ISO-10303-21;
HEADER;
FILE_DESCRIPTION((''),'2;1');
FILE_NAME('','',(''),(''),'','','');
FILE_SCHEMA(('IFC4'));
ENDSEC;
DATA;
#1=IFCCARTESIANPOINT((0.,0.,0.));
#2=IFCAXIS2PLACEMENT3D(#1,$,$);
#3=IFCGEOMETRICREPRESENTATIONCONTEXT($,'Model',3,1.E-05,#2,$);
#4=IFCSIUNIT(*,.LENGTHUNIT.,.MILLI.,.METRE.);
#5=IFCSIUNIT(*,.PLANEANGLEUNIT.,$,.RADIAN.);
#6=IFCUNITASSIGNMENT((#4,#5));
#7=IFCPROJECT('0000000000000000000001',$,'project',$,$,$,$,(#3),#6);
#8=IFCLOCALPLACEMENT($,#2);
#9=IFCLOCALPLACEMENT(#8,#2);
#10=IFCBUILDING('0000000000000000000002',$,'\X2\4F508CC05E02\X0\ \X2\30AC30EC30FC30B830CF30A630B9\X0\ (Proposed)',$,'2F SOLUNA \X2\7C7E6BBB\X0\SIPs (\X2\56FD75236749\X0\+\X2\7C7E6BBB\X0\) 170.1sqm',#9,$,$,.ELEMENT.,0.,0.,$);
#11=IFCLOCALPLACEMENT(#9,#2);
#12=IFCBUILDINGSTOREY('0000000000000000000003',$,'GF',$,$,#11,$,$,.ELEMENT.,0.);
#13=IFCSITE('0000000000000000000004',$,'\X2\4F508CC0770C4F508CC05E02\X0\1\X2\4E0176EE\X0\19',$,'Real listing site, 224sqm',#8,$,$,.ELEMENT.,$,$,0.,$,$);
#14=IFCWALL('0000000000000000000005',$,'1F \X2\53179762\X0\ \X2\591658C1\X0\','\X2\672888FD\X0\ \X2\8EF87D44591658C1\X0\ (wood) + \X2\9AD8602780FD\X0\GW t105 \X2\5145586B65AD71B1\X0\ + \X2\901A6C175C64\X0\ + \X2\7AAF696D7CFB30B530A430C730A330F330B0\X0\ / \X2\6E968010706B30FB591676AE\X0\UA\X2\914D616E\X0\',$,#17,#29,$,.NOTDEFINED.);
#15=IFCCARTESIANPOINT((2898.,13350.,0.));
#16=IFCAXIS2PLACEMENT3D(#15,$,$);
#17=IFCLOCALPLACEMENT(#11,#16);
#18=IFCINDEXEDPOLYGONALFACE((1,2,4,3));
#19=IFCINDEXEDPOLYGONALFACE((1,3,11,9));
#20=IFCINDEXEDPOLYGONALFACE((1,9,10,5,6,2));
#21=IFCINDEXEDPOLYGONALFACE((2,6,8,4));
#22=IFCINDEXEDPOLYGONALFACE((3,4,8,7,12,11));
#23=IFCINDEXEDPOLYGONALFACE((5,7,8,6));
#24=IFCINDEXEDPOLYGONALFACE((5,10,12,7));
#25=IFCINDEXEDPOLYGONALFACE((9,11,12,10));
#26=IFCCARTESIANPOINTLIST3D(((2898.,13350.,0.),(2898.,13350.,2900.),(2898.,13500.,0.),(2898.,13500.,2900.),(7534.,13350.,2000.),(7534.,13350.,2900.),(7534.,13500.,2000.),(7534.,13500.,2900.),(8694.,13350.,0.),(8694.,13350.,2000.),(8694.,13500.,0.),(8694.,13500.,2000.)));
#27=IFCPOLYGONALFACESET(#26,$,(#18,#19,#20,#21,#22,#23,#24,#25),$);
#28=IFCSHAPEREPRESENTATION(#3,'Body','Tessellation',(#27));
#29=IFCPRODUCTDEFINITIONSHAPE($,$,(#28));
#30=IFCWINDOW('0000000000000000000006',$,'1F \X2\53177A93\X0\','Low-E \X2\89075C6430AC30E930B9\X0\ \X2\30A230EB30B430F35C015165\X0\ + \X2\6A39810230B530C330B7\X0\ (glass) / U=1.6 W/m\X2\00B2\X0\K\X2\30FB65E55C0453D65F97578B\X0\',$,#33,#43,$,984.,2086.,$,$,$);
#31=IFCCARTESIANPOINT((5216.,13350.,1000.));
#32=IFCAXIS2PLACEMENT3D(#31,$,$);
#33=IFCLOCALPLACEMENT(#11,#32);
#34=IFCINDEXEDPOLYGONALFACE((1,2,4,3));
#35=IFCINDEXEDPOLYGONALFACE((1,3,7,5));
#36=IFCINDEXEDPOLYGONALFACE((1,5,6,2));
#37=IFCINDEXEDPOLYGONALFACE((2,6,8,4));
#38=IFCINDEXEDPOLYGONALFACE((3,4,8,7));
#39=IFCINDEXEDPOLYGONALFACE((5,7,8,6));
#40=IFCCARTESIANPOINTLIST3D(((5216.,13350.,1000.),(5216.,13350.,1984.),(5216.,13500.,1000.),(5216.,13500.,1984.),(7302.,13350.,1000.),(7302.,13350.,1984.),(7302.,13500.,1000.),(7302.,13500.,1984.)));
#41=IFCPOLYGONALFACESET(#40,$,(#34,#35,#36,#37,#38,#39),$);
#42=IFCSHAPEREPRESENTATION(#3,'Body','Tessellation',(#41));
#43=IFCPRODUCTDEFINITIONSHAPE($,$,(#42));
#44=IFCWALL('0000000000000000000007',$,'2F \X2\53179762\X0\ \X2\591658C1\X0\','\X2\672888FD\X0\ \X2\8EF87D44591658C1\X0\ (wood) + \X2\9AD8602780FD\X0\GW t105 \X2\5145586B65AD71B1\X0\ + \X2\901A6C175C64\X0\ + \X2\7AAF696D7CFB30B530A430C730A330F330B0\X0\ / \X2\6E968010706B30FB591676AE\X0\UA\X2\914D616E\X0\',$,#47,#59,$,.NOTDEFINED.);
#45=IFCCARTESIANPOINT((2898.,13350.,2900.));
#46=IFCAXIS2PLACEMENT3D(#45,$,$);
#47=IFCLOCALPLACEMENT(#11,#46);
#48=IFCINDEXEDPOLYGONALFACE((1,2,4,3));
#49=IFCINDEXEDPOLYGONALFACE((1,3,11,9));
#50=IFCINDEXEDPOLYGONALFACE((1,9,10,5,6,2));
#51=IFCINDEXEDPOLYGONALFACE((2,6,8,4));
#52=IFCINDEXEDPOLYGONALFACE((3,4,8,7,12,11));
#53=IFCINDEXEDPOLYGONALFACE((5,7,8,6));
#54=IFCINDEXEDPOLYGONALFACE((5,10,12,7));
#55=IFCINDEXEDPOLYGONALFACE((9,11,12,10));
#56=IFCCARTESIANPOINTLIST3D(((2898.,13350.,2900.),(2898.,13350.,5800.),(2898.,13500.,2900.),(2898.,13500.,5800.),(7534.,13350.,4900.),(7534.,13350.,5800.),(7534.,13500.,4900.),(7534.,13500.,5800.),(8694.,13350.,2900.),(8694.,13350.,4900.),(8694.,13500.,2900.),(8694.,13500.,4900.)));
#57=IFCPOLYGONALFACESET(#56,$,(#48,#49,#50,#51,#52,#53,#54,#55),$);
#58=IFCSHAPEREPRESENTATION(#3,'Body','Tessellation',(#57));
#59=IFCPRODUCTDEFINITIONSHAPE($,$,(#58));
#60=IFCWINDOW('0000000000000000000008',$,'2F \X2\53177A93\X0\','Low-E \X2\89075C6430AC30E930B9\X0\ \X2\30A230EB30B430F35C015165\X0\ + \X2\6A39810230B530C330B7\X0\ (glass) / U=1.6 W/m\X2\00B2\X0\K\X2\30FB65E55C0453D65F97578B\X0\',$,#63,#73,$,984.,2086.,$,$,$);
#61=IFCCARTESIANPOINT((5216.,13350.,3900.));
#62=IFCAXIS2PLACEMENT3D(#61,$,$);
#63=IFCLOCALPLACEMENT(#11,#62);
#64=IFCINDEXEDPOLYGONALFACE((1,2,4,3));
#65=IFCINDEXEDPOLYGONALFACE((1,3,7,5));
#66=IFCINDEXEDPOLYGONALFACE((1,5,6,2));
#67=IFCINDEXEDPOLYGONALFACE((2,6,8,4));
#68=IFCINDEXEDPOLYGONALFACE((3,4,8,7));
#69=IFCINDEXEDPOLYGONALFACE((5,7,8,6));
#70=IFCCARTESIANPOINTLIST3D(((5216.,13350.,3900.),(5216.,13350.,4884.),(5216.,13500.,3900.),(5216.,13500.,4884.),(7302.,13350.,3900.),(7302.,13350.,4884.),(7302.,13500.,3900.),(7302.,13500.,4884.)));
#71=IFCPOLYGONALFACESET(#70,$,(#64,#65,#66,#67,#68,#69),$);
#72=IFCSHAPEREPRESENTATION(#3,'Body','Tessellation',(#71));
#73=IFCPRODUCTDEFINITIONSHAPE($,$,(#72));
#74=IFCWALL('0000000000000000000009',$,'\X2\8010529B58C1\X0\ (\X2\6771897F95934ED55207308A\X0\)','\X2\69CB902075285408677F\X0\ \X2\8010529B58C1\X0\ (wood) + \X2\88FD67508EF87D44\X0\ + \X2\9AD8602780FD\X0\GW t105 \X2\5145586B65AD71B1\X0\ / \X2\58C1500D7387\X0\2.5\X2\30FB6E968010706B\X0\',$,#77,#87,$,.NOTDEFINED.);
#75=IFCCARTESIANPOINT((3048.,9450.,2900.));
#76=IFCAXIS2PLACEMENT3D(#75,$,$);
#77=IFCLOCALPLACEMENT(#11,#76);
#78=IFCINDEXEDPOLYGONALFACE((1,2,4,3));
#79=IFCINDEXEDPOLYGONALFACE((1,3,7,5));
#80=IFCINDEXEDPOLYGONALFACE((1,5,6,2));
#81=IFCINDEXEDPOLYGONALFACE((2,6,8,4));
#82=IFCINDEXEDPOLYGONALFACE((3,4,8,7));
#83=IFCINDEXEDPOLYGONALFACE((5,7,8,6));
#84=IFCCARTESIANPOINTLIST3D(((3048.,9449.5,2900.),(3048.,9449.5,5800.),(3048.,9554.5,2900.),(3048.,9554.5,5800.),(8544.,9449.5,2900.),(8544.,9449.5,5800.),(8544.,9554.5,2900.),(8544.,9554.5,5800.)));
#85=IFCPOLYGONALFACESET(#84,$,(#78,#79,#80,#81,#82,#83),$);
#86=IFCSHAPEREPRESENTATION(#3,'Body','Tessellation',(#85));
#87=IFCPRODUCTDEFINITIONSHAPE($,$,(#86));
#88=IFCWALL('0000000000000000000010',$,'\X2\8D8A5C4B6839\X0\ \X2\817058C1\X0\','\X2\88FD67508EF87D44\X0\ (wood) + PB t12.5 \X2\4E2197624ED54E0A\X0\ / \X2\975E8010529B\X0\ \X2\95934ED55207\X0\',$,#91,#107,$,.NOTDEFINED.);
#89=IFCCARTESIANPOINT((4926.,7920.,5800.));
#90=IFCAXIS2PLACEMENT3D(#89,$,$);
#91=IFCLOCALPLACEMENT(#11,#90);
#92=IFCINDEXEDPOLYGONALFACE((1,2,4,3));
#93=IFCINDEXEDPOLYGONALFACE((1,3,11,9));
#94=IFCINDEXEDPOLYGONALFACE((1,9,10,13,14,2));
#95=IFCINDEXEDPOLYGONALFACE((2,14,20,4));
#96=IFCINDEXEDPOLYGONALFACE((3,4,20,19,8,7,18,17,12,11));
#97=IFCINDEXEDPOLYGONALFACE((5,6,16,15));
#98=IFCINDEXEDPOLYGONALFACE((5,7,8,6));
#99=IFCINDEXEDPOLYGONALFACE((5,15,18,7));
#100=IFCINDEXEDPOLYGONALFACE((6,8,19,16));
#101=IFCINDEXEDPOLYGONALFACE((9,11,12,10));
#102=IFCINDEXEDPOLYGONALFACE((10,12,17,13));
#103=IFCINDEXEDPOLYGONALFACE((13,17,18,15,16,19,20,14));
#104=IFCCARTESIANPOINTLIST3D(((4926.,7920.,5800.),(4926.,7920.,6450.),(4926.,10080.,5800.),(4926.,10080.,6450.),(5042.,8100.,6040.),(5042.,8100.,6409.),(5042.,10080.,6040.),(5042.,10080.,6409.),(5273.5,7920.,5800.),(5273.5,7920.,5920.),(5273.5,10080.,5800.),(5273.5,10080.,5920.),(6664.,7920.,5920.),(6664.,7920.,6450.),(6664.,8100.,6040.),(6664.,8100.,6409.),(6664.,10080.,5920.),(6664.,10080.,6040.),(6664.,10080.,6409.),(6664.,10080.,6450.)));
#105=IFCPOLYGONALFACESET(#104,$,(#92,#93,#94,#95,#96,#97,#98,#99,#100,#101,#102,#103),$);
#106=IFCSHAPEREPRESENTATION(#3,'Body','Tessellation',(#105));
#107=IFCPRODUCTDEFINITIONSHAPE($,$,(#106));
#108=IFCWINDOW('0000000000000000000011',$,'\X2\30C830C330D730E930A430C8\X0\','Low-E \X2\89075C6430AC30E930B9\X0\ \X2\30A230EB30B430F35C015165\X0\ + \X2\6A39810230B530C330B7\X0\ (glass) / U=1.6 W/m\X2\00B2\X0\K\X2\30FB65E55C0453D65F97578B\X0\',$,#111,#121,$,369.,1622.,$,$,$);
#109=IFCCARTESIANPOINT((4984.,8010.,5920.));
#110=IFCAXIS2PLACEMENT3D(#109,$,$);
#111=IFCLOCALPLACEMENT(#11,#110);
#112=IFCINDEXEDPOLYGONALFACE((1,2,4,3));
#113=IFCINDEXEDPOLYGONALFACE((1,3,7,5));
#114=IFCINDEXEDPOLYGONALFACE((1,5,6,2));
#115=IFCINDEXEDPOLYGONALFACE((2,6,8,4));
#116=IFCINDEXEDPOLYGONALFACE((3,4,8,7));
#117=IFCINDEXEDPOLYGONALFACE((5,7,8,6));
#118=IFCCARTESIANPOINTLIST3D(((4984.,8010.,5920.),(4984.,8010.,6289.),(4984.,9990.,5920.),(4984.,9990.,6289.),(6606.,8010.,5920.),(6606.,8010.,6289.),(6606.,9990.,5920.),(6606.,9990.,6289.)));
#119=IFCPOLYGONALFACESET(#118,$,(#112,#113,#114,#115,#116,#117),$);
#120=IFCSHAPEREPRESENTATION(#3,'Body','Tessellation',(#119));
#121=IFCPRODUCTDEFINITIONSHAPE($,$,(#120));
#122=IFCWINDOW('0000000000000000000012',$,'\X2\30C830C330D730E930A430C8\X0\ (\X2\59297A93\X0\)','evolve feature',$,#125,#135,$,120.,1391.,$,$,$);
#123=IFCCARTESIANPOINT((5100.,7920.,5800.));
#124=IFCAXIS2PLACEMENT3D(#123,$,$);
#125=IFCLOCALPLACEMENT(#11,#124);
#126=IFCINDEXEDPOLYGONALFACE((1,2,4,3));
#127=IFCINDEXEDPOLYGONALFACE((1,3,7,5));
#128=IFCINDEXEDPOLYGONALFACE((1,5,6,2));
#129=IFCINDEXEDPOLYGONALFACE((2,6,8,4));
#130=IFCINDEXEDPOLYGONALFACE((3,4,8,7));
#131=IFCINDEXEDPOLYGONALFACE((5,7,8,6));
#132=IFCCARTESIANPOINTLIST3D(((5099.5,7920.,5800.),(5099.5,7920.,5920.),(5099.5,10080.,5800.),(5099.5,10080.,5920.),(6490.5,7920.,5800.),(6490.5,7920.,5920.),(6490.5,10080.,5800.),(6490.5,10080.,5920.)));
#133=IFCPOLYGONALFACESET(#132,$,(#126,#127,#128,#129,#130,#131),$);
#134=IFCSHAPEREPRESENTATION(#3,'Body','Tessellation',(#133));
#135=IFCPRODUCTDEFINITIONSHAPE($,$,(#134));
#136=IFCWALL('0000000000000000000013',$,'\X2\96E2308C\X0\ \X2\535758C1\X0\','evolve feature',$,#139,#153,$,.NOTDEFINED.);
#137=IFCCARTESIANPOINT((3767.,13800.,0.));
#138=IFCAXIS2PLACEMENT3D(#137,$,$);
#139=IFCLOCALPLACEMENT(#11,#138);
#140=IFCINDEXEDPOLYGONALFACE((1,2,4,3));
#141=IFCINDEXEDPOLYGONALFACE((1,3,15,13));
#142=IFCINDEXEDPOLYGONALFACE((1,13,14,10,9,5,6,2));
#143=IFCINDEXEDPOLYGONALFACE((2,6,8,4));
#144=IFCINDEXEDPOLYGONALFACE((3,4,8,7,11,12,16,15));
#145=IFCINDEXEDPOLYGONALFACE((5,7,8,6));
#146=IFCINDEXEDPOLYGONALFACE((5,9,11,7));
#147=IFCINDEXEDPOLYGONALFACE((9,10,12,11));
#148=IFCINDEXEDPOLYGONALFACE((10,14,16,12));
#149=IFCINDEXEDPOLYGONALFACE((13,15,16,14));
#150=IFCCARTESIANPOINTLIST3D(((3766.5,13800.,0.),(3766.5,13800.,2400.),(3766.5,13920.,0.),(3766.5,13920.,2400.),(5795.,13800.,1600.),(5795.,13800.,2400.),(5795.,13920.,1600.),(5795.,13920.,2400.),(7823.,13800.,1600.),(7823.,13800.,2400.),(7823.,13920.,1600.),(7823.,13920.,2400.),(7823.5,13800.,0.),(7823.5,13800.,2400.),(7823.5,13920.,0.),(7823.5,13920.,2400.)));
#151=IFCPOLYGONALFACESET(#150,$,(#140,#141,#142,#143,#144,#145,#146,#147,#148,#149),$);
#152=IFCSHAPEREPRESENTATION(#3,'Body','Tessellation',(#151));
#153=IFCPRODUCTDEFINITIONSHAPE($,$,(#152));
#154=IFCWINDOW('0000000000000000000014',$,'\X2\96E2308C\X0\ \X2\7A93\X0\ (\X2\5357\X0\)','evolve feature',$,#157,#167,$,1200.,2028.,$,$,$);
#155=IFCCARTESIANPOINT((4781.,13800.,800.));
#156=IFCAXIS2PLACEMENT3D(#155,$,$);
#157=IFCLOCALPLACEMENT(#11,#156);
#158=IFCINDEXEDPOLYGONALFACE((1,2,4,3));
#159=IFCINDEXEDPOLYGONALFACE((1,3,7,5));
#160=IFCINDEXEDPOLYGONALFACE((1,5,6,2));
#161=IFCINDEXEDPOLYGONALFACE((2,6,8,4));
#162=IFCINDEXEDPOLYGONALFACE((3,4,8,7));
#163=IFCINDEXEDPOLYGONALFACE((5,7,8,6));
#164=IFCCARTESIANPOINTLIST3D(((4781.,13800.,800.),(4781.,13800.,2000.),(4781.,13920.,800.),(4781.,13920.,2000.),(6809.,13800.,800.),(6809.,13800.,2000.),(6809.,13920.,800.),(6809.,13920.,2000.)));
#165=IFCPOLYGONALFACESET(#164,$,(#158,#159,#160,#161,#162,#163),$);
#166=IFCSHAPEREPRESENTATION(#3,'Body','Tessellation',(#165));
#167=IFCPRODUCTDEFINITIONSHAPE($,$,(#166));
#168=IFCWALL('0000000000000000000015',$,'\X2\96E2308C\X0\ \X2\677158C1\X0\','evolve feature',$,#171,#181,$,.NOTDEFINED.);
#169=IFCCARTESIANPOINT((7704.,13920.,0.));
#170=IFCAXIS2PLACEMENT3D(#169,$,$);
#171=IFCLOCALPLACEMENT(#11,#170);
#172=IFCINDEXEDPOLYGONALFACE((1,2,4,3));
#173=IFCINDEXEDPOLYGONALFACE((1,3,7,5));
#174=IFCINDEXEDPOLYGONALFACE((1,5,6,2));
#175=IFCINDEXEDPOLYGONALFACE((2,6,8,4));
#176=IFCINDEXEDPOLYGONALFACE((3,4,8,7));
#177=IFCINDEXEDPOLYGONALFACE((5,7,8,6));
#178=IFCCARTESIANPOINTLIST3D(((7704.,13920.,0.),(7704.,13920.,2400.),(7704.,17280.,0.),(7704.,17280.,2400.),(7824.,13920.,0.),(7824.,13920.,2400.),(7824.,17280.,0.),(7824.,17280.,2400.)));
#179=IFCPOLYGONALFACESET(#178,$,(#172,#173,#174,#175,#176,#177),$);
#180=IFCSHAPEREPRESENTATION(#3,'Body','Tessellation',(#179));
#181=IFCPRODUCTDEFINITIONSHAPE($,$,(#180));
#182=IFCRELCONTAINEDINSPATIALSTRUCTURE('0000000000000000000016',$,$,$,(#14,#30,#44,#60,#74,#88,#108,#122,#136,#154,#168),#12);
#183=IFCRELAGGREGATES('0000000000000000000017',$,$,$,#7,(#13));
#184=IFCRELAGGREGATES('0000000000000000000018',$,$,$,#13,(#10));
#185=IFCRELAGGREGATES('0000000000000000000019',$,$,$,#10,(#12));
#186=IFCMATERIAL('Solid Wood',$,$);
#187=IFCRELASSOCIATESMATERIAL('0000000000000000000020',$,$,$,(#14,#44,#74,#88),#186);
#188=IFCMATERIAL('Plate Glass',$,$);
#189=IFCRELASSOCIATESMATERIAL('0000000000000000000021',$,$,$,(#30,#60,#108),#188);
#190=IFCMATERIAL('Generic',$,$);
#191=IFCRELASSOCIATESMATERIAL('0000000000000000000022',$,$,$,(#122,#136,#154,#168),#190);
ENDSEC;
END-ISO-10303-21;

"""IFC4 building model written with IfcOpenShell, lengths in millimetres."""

from ifc_helpers import new_model, si_unit, frame, frame_2d, origin, place, context, project, spatial, rectangle, extrude, material, element, fill, save


model = new_model("IFC4")

# Units and contexts
model_context = context("Model", 3, precision=1e-05, world=origin())
ifc_project = project(units=[si_unit("LENGTHUNIT", "METRE", prefix="MILLI"), si_unit("PLANEANGLEUNIT", "RADIAN")], contexts=[model_context])

# Site, building, storey
site_placement = place(None, origin())
site = spatial("IfcSite", under=ifc_project, at=site_placement, Name="佐賀県佐賀市1丁目19", ObjectType="Real listing site, 224sqm", CompositionType="ELEMENT", RefElevation=0.0)
building_placement = place(site_placement, origin())
building = spatial("IfcBuilding", under=site, at=building_placement, Name="佐賀市 ガレージハウス (Proposed)", ObjectType="2F SOLUNA 籾殻SIPs (国産杉+籾殻) 170.1sqm", CompositionType="ELEMENT", ElevationOfRefHeight=0.0, ElevationOfTerrain=0.0)
storey_placement = place(building_placement, origin())
storey = spatial("IfcBuildingStorey", under=building, at=storey_placement, Name="GF", CompositionType="ELEMENT", Elevation=0.0)

# Shared definitions
ifc_material_1 = material(Name="Generic")

# Wall, opening, window
ifc_material_2 = material(Name="Solid Wood")
wall_1_placement = place(storey_placement, frame((2898.0, 13350.0, 0.0)))
wall_1 = element("IfcWall", 1, at=wall_1_placement, inside=storey, material=ifc_material_2, Name="1F 北面 外壁", Description="木製 軸組外壁 (wood) + 高性能GW t105 充填断熱 + 通気層 + 窯業系サイディング / 準耐火・外皮UA配慮", PredefinedType="NOTDEFINED", context=model_context, shape_type="SweptSolid", body=[
    extrude(rectangle(XDim=5796.0, YDim=150.0, at=frame_2d((2898.0, 75.0))), frame((2898.0, 13350.0, 0.0)), (0.0, 0.0, 1.0), 2900.0),
])
opening_1_placement = place(storey_placement, frame((5216.0, 13350.0, 1000.0)))
opening_1 = element("IfcOpeningElement", 2, at=opening_1_placement, cuts=wall_1, PredefinedType="NOTDEFINED", context=model_context, shape_type="SweptSolid", body=[
    extrude(rectangle(XDim=2086.0, YDim=150.0, at=frame_2d((1043.0, 75.0))), frame((5216.0, 13350.0, 1000.0)), (0.0, 0.0, 1.0), 984.0),
])
ifc_material_3 = material(Name="Plate Glass")
window_1_placement = place(storey_placement, frame((5216.0, 13350.0, 1000.0)))
window_1 = element("IfcWindow", 3, at=window_1_placement, inside=storey, material=ifc_material_3, Name="1F 北窓", Description="Low-E 複層ガラス アルゴン封入 + 樹脂サッシ (glass) / U=1.6 W/m²K・日射取得型", OverallHeight=984.0, OverallWidth=2086.0, context=model_context, shape_type="SweptSolid", body=[
    extrude(rectangle(XDim=2086.0, YDim=150.0, at=frame_2d((1043.0, 75.0))), frame((5216.0, 13350.0, 1000.0)), (0.0, 0.0, 1.0), 984.0),
])
fill(opening_1, window_1)

# Wall, opening, window
wall_2_placement = place(storey_placement, frame((2898.0, 13350.0, 2900.0)))
wall_2 = element("IfcWall", 4, at=wall_2_placement, inside=storey, material=ifc_material_2, Name="2F 北面 外壁", Description="木製 軸組外壁 (wood) + 高性能GW t105 充填断熱 + 通気層 + 窯業系サイディング / 準耐火・外皮UA配慮", PredefinedType="NOTDEFINED", context=model_context, shape_type="SweptSolid", body=[
    extrude(rectangle(XDim=5796.0, YDim=150.0, at=frame_2d((2898.0, 75.0))), frame((2898.0, 13350.0, 2900.0)), (0.0, 0.0, 1.0), 2900.0),
])
opening_2_placement = place(storey_placement, frame((5216.0, 13350.0, 3900.0)))
opening_2 = element("IfcOpeningElement", 5, at=opening_2_placement, cuts=wall_2, PredefinedType="NOTDEFINED", context=model_context, shape_type="SweptSolid", body=[
    extrude(rectangle(XDim=2086.0, YDim=150.0, at=frame_2d((1043.0, 75.0))), frame((5216.0, 13350.0, 3900.0)), (0.0, 0.0, 1.0), 984.0),
])
window_2_placement = place(storey_placement, frame((5216.0, 13350.0, 3900.0)))
window_2 = element("IfcWindow", 6, at=window_2_placement, inside=storey, material=ifc_material_3, Name="2F 北窓", Description="Low-E 複層ガラス アルゴン封入 + 樹脂サッシ (glass) / U=1.6 W/m²K・日射取得型", OverallHeight=984.0, OverallWidth=2086.0, context=model_context, shape_type="SweptSolid", body=[
    extrude(rectangle(XDim=2086.0, YDim=150.0, at=frame_2d((1043.0, 75.0))), frame((5216.0, 13350.0, 3900.0)), (0.0, 0.0, 1.0), 984.0),
])
fill(opening_2, window_2)

# Wall
wall_3_placement = place(storey_placement, frame((3048.0, 9450.0, 2900.0)))
element("IfcWall", 7, at=wall_3_placement, inside=storey, material=ifc_material_2, Name="耐力壁 (東西間仕切り)", Description="構造用合板 耐力壁 (wood) + 製材軸組 + 高性能GW t105 充填断熱 / 壁倍率2.5・準耐火", PredefinedType="NOTDEFINED", context=model_context, shape_type="SweptSolid", body=[
    extrude(rectangle(XDim=5496.0, YDim=105.0, at=frame_2d((2748.0, 52.0))), frame((3048.0, 9450.0, 2900.0)), (0.0, 0.0, 1.0), 2900.0),
])

# Wall, openings, windows
wall_4_placement = place(storey_placement, frame((4926.0, 7920.0, 5800.0)))
wall_4 = element("IfcWall", 8, at=wall_4_placement, inside=storey, material=ifc_material_2, Name="越屋根 腰壁", Description="製材軸組 (wood) + PB t12.5 両面仕上 / 非耐力 間仕切", PredefinedType="NOTDEFINED", context=model_context, shape_type="SweptSolid", body=[
    extrude(rectangle(XDim=1738.0, YDim=2160.0, at=frame_2d((869.0, 1080.0))), frame((4926.0, 7920.0, 5800.0)), (0.0, 0.0, 1.0), 650.0),
])
opening_3_placement = place(storey_placement, frame((4984.0, 8010.0, 5920.0)))
opening_3 = element("IfcOpeningElement", 9, at=opening_3_placement, cuts=wall_4, PredefinedType="NOTDEFINED", context=model_context, shape_type="SweptSolid", body=[
    extrude(rectangle(XDim=1622.0, YDim=1980.0, at=frame_2d((811.0, 990.0))), frame((4984.0, 8010.0, 5920.0)), (0.0, 0.0, 1.0), 369.0),
])
opening_4_placement = place(storey_placement, frame((5100.0, 7920.0, 5800.0)))
opening_4 = element("IfcOpeningElement", 10, at=opening_4_placement, cuts=wall_4, PredefinedType="NOTDEFINED", context=model_context, shape_type="SweptSolid", body=[
    extrude(rectangle(XDim=1391.0, YDim=2160.0, at=frame_2d((695.0, 1080.0))), frame((5100.0, 7920.0, 5800.0)), (0.0, 0.0, 1.0), 120.0),
])
window_3_placement = place(storey_placement, frame((4984.0, 8010.0, 5920.0)))
window_3 = element("IfcWindow", 11, at=window_3_placement, inside=storey, material=ifc_material_3, Name="トップライト", Description="Low-E 複層ガラス アルゴン封入 + 樹脂サッシ (glass) / U=1.6 W/m²K・日射取得型", OverallHeight=369.0, OverallWidth=1622.0, context=model_context, shape_type="SweptSolid", body=[
    extrude(rectangle(XDim=1622.0, YDim=1980.0, at=frame_2d((811.0, 990.0))), frame((4984.0, 8010.0, 5920.0)), (0.0, 0.0, 1.0), 369.0),
])
fill(opening_3, window_3)
window_4_placement = place(storey_placement, frame((5100.0, 7920.0, 5800.0)))
window_4 = element("IfcWindow", 12, at=window_4_placement, inside=storey, material=ifc_material_1, Name="トップライト (天窓)", Description="evolve feature", OverallHeight=120.0, OverallWidth=1391.0, context=model_context, shape_type="SweptSolid", body=[
    extrude(rectangle(XDim=1391.0, YDim=2160.0, at=frame_2d((695.0, 1080.0))), frame((5100.0, 7920.0, 5800.0)), (0.0, 0.0, 1.0), 120.0),
])
fill(opening_4, window_4)

# Wall, opening, window
wall_5_placement = place(storey_placement, frame((3767.0, 13800.0, 0.0)))
wall_5 = element("IfcWall", 13, at=wall_5_placement, inside=storey, material=ifc_material_1, Name="離れ 南壁", Description="evolve feature", PredefinedType="NOTDEFINED", context=model_context, shape_type="SweptSolid", body=[
    extrude(rectangle(XDim=4057.0, YDim=120.0, at=frame_2d((2028.0, 60.0))), frame((3767.0, 13800.0, 0.0)), (0.0, 0.0, 1.0), 2400.0),
])
opening_5_placement = place(storey_placement, frame((4781.0, 13800.0, 800.0)))
opening_5 = element("IfcOpeningElement", 14, at=opening_5_placement, cuts=wall_5, PredefinedType="NOTDEFINED", context=model_context, shape_type="SweptSolid", body=[
    extrude(rectangle(XDim=2028.0, YDim=120.0, at=frame_2d((1014.0, 60.0))), frame((4781.0, 13800.0, 800.0)), (0.0, 0.0, 1.0), 1200.0),
])
window_5_placement = place(storey_placement, frame((4781.0, 13800.0, 800.0)))
window_5 = element("IfcWindow", 15, at=window_5_placement, inside=storey, material=ifc_material_1, Name="離れ 窓 (南)", Description="evolve feature", OverallHeight=1200.0, OverallWidth=2028.0, context=model_context, shape_type="SweptSolid", body=[
    extrude(rectangle(XDim=2028.0, YDim=120.0, at=frame_2d((1014.0, 60.0))), frame((4781.0, 13800.0, 800.0)), (0.0, 0.0, 1.0), 1200.0),
])
fill(opening_5, window_5)

# Wall
wall_6_placement = place(storey_placement, frame((7704.0, 13920.0, 0.0)))
element("IfcWall", 16, at=wall_6_placement, inside=storey, material=ifc_material_1, Name="離れ 東壁", Description="evolve feature", PredefinedType="NOTDEFINED", context=model_context, shape_type="SweptSolid", body=[
    extrude(rectangle(XDim=120.0, YDim=3360.0, at=frame_2d((60.0, 1680.0))), frame((7704.0, 13920.0, 0.0)), (0.0, 0.0, 1.0), 2400.0),
])

save(model, "model.ifc")
